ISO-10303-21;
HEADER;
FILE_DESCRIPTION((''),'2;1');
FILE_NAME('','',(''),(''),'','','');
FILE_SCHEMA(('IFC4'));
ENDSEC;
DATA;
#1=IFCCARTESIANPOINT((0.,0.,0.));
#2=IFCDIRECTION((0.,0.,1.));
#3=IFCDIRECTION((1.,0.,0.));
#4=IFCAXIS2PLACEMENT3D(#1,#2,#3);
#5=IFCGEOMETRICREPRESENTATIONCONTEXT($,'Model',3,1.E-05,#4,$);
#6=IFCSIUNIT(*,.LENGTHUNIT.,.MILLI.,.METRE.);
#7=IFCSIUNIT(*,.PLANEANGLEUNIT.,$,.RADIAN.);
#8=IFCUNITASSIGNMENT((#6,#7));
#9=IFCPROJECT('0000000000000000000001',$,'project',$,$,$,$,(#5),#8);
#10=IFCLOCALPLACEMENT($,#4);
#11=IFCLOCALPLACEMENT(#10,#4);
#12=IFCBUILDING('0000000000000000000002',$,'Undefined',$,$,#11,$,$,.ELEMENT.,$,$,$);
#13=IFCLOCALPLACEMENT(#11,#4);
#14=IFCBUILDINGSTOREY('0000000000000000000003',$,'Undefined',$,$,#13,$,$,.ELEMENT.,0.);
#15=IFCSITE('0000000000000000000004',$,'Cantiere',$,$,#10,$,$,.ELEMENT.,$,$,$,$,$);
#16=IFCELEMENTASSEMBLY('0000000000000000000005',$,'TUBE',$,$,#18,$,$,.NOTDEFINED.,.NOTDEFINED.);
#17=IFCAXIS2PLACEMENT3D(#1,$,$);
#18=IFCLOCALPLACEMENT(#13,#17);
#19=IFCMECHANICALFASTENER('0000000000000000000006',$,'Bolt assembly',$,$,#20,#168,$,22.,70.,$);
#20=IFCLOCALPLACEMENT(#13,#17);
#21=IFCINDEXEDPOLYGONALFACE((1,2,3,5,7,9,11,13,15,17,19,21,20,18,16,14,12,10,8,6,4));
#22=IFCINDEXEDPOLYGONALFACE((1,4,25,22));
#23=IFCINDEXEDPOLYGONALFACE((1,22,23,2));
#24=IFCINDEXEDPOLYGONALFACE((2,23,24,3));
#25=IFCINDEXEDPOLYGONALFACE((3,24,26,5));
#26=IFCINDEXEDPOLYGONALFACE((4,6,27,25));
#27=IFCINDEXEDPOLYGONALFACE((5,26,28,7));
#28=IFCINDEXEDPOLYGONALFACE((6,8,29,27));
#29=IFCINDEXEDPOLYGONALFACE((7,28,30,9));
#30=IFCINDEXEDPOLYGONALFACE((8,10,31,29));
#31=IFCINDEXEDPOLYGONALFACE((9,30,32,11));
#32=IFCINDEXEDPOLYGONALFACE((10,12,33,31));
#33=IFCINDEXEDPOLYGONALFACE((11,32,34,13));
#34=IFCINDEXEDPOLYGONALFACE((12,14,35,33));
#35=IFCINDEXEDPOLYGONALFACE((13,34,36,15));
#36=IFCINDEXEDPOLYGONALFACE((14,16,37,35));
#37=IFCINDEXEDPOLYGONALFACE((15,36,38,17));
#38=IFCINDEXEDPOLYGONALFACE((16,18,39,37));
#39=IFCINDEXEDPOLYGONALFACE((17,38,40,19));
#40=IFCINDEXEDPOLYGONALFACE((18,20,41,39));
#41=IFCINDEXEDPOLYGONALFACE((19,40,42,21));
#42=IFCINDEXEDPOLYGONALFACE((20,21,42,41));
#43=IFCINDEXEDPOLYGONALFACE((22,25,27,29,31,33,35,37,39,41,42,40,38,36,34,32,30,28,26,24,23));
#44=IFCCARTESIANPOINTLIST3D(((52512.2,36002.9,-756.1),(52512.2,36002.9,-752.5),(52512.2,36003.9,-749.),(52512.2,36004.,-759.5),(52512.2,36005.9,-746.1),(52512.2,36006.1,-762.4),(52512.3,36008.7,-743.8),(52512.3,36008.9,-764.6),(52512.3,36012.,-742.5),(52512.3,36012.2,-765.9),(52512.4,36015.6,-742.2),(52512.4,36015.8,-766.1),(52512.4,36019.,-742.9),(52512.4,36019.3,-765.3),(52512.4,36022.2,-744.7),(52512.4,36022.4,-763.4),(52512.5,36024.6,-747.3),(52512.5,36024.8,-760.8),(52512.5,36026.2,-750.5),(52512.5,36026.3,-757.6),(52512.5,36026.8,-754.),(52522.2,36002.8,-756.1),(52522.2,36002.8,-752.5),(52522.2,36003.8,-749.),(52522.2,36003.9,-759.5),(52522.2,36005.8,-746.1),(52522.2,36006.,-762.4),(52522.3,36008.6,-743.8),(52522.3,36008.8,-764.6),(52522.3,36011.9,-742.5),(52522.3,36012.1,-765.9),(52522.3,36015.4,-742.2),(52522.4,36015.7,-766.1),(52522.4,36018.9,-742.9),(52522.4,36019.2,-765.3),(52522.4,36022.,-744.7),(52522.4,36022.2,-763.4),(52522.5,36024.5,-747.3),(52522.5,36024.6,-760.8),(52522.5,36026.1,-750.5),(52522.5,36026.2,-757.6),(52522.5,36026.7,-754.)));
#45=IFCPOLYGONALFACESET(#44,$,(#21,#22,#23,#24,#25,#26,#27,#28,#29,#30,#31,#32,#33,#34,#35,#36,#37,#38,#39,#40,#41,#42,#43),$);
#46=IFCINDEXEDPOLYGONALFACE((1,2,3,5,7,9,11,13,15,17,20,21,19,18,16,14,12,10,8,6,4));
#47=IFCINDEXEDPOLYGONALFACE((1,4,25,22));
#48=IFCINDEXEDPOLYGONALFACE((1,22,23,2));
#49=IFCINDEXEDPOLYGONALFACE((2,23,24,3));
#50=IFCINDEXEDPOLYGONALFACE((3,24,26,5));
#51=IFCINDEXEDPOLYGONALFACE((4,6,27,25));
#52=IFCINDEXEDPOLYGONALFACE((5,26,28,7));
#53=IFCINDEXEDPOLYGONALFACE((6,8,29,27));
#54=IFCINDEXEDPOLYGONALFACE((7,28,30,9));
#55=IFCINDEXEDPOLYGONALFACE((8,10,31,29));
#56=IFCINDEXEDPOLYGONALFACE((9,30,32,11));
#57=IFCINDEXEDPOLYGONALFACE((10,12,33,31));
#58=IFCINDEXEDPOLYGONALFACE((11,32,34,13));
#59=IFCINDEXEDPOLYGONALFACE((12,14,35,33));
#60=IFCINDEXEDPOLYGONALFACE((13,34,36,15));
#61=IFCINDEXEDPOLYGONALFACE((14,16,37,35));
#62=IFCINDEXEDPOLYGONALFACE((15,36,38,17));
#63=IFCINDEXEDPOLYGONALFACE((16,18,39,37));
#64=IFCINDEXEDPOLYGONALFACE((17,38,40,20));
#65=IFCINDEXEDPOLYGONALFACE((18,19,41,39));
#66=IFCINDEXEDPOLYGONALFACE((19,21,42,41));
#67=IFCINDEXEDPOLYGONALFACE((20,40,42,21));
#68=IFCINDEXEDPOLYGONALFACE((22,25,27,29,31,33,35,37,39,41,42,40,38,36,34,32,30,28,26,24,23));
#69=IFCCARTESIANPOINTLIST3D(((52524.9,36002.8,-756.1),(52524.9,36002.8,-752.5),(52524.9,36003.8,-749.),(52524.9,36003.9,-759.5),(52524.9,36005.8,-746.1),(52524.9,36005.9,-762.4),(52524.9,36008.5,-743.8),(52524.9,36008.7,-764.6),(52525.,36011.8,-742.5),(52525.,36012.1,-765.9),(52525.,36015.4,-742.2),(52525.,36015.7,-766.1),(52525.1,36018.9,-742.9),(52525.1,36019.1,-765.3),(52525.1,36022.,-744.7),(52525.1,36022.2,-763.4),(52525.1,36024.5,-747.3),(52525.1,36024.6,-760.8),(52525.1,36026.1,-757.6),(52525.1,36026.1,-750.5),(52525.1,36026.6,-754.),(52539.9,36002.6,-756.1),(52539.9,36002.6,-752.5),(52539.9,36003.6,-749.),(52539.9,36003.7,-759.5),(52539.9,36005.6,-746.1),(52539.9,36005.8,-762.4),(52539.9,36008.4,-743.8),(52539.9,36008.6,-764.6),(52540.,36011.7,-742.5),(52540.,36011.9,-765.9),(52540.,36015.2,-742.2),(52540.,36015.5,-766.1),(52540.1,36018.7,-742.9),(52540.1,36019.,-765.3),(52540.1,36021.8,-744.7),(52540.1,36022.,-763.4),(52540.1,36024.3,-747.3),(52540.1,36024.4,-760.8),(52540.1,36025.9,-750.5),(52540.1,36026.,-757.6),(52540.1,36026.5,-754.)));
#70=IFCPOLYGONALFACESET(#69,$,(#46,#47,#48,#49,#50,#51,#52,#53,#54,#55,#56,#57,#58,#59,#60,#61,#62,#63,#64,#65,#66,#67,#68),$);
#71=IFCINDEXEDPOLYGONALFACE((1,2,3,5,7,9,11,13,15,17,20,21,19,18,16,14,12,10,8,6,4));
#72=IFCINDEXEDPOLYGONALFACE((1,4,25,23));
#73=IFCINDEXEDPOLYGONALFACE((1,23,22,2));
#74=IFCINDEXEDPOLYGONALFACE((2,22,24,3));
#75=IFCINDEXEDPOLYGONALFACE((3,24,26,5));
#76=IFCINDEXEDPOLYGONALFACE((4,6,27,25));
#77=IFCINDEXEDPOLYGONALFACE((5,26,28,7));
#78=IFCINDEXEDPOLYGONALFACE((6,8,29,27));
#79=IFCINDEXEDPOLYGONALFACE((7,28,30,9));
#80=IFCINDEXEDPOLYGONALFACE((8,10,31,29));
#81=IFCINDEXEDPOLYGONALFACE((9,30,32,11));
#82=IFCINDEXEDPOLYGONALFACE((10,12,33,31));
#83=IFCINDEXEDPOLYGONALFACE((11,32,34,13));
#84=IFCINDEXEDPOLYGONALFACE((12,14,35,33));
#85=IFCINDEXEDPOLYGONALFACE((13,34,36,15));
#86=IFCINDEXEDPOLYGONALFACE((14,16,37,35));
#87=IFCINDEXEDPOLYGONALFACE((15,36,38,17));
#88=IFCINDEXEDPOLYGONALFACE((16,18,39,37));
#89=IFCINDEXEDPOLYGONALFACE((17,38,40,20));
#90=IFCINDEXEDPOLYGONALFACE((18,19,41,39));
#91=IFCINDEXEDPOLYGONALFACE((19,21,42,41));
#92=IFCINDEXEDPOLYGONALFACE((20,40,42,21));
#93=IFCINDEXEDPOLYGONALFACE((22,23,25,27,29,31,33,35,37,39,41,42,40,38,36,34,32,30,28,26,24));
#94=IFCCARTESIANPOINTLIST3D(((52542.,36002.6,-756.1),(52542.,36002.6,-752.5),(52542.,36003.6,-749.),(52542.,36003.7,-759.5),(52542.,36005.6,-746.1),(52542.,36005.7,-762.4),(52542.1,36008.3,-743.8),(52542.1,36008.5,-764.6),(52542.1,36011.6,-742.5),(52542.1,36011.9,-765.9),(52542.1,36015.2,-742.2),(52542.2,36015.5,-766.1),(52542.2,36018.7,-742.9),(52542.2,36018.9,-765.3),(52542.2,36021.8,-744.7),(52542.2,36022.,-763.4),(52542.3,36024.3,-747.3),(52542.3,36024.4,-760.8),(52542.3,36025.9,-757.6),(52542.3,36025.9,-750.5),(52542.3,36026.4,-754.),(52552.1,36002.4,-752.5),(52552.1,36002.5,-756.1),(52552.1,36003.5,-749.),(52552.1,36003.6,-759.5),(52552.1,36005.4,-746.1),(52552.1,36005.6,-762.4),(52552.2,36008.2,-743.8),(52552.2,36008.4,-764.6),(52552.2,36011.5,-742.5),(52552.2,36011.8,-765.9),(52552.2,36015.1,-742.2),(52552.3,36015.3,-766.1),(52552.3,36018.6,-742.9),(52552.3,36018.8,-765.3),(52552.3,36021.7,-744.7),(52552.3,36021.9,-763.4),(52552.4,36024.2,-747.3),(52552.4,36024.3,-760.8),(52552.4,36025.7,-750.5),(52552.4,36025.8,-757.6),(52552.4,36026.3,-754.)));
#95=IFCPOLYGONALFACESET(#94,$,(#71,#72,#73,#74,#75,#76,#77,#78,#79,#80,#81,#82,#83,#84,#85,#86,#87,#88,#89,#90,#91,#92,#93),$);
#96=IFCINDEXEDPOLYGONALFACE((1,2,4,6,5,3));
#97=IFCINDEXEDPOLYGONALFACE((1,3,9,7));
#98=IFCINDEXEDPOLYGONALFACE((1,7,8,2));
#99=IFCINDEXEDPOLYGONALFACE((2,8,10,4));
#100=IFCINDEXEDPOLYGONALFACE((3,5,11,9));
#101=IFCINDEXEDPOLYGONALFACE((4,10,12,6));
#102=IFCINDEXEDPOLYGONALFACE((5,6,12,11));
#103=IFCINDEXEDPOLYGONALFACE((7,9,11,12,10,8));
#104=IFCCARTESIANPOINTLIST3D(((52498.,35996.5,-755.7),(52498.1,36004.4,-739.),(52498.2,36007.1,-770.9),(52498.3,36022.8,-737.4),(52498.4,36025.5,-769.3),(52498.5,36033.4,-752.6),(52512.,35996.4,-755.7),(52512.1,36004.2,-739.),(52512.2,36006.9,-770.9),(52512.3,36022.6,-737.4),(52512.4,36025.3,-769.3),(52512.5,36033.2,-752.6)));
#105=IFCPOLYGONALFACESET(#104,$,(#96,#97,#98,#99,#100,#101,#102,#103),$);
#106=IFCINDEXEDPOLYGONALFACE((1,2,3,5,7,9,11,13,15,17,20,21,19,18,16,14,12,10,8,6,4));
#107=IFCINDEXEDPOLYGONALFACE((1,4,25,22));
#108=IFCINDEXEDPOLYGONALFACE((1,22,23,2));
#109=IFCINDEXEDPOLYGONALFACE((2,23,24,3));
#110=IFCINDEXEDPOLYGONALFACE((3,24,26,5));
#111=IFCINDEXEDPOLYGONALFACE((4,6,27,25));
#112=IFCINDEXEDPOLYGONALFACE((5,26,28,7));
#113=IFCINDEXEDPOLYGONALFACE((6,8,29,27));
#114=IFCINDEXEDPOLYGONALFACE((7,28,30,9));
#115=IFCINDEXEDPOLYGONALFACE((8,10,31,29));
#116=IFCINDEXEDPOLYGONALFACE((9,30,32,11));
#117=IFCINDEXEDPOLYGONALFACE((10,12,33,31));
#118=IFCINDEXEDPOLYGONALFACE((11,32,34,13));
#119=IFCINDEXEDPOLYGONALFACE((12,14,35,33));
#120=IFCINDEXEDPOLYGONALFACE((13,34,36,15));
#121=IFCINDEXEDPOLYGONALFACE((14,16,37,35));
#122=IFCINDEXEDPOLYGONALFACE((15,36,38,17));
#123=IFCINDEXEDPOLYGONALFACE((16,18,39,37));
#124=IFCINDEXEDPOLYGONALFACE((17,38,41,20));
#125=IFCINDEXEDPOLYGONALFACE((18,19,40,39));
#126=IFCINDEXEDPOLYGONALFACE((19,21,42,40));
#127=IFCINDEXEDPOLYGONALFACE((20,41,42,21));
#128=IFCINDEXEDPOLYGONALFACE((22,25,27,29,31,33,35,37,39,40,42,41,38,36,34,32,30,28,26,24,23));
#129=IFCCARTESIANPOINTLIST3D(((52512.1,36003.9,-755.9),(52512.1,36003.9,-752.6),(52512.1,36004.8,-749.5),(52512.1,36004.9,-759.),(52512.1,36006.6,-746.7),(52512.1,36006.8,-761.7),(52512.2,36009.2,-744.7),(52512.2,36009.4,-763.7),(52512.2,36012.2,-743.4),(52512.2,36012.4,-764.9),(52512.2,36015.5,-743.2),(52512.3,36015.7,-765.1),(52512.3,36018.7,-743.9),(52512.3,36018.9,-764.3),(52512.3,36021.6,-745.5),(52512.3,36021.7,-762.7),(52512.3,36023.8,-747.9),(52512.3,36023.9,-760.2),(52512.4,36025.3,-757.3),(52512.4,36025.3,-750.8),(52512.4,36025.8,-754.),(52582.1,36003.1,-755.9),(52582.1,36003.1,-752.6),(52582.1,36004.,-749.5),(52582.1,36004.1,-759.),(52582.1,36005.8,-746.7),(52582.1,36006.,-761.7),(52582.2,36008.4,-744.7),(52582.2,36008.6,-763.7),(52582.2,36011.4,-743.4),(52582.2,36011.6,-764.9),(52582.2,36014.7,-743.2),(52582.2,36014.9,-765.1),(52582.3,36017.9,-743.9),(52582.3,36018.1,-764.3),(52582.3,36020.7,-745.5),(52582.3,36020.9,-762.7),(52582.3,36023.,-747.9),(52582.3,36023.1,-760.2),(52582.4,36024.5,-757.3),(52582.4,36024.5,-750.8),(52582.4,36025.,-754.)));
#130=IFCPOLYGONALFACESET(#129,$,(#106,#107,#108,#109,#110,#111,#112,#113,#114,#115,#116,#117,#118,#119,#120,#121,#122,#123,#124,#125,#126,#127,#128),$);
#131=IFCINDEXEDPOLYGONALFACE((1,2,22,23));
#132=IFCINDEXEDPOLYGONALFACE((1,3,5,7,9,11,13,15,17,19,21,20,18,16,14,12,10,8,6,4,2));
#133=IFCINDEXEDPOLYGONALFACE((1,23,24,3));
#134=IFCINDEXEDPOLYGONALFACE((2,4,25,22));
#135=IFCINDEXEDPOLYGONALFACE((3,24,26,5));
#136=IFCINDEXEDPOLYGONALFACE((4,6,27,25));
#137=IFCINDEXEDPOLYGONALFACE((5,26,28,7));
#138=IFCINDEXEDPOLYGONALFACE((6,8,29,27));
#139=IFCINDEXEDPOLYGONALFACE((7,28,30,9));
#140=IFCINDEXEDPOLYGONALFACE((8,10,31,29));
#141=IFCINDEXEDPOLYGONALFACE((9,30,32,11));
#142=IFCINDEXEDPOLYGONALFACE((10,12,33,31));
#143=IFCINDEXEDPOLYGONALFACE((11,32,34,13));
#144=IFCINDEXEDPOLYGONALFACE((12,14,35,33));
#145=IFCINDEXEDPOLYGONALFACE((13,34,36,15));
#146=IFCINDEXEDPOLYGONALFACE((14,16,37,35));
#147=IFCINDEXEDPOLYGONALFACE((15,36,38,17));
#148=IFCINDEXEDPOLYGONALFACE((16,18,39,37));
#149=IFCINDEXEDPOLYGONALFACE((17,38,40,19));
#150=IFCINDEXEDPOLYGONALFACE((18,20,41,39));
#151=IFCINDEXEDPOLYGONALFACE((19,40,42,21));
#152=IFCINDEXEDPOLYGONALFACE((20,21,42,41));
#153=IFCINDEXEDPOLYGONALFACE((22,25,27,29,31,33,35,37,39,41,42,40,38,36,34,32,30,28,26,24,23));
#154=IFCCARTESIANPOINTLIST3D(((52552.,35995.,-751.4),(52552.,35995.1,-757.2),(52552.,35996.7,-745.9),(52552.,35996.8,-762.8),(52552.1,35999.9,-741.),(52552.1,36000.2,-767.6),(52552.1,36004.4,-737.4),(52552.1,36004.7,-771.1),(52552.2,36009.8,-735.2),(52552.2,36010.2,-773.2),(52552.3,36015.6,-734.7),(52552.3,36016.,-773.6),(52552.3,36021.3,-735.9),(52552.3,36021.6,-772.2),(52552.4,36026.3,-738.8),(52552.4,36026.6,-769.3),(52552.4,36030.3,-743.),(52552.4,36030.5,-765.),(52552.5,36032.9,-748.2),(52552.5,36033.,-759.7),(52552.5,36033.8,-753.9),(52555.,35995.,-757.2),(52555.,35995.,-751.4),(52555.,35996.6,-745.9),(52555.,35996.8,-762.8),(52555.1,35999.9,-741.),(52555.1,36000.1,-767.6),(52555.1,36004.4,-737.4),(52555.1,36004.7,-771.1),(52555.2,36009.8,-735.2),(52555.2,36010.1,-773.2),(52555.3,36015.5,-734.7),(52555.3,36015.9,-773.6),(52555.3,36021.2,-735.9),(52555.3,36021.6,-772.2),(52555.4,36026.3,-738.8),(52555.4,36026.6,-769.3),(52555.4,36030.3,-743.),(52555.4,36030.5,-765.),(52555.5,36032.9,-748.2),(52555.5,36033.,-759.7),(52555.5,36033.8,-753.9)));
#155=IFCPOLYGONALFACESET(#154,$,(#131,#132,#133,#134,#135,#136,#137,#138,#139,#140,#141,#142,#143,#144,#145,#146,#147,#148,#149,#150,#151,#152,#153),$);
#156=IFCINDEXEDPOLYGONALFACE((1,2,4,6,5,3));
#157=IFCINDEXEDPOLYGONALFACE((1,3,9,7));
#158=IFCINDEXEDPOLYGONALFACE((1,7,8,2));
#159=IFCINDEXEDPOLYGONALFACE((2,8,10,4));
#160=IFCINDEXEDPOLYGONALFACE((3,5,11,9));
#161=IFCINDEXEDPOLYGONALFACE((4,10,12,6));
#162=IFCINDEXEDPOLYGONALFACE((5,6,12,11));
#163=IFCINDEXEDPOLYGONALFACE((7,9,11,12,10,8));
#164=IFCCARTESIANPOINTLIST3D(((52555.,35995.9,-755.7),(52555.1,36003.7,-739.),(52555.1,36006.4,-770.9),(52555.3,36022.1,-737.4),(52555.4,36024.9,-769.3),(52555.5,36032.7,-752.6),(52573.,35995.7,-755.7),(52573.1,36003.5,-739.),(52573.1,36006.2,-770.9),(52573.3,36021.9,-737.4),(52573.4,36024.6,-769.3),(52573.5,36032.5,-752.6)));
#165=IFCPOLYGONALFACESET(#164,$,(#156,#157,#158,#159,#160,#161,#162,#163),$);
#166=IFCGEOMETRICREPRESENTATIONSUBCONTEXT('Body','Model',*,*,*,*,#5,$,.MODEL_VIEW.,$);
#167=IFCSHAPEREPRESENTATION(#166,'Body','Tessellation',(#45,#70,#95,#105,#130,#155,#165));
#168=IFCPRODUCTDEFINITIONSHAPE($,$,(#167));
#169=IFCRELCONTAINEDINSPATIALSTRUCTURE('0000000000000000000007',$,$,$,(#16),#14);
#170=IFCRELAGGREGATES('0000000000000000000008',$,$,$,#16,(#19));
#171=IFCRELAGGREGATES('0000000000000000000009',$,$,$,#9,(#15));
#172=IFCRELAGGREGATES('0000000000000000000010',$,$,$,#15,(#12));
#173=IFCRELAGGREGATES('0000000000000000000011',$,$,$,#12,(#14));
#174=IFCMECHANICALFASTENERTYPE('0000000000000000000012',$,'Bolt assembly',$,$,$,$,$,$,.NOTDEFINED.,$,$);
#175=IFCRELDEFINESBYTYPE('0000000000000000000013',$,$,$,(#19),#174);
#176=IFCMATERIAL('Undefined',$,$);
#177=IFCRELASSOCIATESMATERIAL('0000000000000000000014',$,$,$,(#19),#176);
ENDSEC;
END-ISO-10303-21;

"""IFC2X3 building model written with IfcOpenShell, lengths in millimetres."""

from ifc_helpers import new_model, si_unit, frame, origin_with_axes, origin_2d_with_axis, place, context, subcontext, project, spatial, polyline, circle, outline, extrude, source, transform, mapped, material, type_object, element, aggregate, save


model = new_model("IFC2X3")

# Units and contexts
model_context = context("Model", 3, precision=1e-05, world=origin_with_axes())
body_context = subcontext(model_context, "Body", "Model", "MODEL_VIEW")
ifc_project = project(units=[si_unit("LENGTHUNIT", "METRE", prefix="MILLI"), si_unit("PLANEANGLEUNIT", "RADIAN")], contexts=[model_context])

# Site, building, storey
site_placement = place(None, origin_with_axes())
site = spatial("IfcSite", under=ifc_project, at=site_placement, Name="Cantiere", CompositionType="ELEMENT")
building_placement = place(site_placement, origin_with_axes())
building = spatial("IfcBuilding", under=site, at=building_placement, Name="Undefined", CompositionType="ELEMENT")
storey_placement = place(building_placement, origin_with_axes())
storey = spatial("IfcBuildingStorey", under=building, at=storey_placement, Name="Undefined", CompositionType="ELEMENT", Elevation=0.0)

# Element assembly
assembly_1_placement = place(storey_placement, origin_with_axes())
assembly_1 = element("IfcElementAssembly", 1, at=assembly_1_placement, inside=storey, Name="TUBE", AssemblyPlace="NOTDEFINED", PredefinedType="NOTDEFINED")

# Mechanical fastener
ifc_material_1 = material(Name="Undefined")
mechanical_fastener_type = type_object("IfcMechanicalFastenerType", Name="Bolt assembly")
shared_shape = source(origin_with_axes(), body_context, "Body", "SweptSolid", [
    extrude(circle(Radius=12.0, at=origin_2d_with_axis()), frame((0.0, -39.9, 0.0), z_axis=(0.0, 1.0, 0.0), x_axis=(1.0, 0.0, 0.0)), (0.0, 0.0, 1.0), 10.0),
    extrude(circle(Radius=12.0, at=origin_2d_with_axis()), frame((0.0, -27.2, 0.0), z_axis=(0.0, 1.0, 0.0), x_axis=(1.0, 0.0, 0.0)), (0.0, 0.0, 1.0), 15.0),
    extrude(circle(Radius=12.0, at=origin_2d_with_axis()), frame((0.0, -10.1, 0.0), z_axis=(0.0, 1.0, 0.0), x_axis=(1.0, 0.0, 0.0)), (0.0, 0.0, 1.0), 10.1),
    extrude(outline(polyline([(16.0, -9.2), (16.0, 9.2), (0.0, 18.5), (-16.0, 9.2), (-16.0, -9.2), (0.0, -18.5), (16.0, -9.2)])), frame((0.0, -54.0, 0.0), z_axis=(0.0, 1.0, 0.0), x_axis=(1.0, 0.0, 0.0)), (0.0, 0.0, 1.0), 14.0),
    extrude(circle(Radius=11.0, at=origin_2d_with_axis()), frame((0.0, -40.0, 0.0), z_axis=(0.0, 1.0, 0.0), x_axis=(1.0, 0.0, 0.0)), (0.0, 0.0, 1.0), 70.0),
    extrude(circle(Radius=19.5, at=origin_2d_with_axis()), frame((0.0, 0.0, 0.0), z_axis=(0.0, 1.0, 0.0), x_axis=(1.0, 0.0, 0.0)), (0.0, 0.0, 1.0), 3.0),
    extrude(outline(polyline([(16.0, -9.2), (16.0, 9.2), (0.0, 18.5), (-16.0, 9.2), (-16.0, -9.2), (0.0, -18.5), (16.0, -9.2)])), frame((0.0, 3.0, 0.0), z_axis=(0.0, 1.0, 0.0), x_axis=(1.0, 0.0, 0.0)), (0.0, 0.0, 1.0), 18.0),
])
mechanical_fastener_1_placement = place(assembly_1_placement, frame((52552.2, 36014.3, -754.1), z_axis=(0.004912, 0.424509, 0.905411), x_axis=(-0.01046, -0.90535, 0.424537)))
mechanical_fastener_1 = element("IfcMechanicalFastener", 2, at=mechanical_fastener_1_placement, type_object=mechanical_fastener_type, material=ifc_material_1, Name="Bolt assembly", NominalDiameter=22.0, NominalLength=70.0, context=body_context, shape_type="MappedRepresentation", body=[
    mapped(shared_shape, transform((0.0, 0.0, 0.0))),
])
aggregate(assembly_1, [mechanical_fastener_1])

save(model, "model.ifc")
